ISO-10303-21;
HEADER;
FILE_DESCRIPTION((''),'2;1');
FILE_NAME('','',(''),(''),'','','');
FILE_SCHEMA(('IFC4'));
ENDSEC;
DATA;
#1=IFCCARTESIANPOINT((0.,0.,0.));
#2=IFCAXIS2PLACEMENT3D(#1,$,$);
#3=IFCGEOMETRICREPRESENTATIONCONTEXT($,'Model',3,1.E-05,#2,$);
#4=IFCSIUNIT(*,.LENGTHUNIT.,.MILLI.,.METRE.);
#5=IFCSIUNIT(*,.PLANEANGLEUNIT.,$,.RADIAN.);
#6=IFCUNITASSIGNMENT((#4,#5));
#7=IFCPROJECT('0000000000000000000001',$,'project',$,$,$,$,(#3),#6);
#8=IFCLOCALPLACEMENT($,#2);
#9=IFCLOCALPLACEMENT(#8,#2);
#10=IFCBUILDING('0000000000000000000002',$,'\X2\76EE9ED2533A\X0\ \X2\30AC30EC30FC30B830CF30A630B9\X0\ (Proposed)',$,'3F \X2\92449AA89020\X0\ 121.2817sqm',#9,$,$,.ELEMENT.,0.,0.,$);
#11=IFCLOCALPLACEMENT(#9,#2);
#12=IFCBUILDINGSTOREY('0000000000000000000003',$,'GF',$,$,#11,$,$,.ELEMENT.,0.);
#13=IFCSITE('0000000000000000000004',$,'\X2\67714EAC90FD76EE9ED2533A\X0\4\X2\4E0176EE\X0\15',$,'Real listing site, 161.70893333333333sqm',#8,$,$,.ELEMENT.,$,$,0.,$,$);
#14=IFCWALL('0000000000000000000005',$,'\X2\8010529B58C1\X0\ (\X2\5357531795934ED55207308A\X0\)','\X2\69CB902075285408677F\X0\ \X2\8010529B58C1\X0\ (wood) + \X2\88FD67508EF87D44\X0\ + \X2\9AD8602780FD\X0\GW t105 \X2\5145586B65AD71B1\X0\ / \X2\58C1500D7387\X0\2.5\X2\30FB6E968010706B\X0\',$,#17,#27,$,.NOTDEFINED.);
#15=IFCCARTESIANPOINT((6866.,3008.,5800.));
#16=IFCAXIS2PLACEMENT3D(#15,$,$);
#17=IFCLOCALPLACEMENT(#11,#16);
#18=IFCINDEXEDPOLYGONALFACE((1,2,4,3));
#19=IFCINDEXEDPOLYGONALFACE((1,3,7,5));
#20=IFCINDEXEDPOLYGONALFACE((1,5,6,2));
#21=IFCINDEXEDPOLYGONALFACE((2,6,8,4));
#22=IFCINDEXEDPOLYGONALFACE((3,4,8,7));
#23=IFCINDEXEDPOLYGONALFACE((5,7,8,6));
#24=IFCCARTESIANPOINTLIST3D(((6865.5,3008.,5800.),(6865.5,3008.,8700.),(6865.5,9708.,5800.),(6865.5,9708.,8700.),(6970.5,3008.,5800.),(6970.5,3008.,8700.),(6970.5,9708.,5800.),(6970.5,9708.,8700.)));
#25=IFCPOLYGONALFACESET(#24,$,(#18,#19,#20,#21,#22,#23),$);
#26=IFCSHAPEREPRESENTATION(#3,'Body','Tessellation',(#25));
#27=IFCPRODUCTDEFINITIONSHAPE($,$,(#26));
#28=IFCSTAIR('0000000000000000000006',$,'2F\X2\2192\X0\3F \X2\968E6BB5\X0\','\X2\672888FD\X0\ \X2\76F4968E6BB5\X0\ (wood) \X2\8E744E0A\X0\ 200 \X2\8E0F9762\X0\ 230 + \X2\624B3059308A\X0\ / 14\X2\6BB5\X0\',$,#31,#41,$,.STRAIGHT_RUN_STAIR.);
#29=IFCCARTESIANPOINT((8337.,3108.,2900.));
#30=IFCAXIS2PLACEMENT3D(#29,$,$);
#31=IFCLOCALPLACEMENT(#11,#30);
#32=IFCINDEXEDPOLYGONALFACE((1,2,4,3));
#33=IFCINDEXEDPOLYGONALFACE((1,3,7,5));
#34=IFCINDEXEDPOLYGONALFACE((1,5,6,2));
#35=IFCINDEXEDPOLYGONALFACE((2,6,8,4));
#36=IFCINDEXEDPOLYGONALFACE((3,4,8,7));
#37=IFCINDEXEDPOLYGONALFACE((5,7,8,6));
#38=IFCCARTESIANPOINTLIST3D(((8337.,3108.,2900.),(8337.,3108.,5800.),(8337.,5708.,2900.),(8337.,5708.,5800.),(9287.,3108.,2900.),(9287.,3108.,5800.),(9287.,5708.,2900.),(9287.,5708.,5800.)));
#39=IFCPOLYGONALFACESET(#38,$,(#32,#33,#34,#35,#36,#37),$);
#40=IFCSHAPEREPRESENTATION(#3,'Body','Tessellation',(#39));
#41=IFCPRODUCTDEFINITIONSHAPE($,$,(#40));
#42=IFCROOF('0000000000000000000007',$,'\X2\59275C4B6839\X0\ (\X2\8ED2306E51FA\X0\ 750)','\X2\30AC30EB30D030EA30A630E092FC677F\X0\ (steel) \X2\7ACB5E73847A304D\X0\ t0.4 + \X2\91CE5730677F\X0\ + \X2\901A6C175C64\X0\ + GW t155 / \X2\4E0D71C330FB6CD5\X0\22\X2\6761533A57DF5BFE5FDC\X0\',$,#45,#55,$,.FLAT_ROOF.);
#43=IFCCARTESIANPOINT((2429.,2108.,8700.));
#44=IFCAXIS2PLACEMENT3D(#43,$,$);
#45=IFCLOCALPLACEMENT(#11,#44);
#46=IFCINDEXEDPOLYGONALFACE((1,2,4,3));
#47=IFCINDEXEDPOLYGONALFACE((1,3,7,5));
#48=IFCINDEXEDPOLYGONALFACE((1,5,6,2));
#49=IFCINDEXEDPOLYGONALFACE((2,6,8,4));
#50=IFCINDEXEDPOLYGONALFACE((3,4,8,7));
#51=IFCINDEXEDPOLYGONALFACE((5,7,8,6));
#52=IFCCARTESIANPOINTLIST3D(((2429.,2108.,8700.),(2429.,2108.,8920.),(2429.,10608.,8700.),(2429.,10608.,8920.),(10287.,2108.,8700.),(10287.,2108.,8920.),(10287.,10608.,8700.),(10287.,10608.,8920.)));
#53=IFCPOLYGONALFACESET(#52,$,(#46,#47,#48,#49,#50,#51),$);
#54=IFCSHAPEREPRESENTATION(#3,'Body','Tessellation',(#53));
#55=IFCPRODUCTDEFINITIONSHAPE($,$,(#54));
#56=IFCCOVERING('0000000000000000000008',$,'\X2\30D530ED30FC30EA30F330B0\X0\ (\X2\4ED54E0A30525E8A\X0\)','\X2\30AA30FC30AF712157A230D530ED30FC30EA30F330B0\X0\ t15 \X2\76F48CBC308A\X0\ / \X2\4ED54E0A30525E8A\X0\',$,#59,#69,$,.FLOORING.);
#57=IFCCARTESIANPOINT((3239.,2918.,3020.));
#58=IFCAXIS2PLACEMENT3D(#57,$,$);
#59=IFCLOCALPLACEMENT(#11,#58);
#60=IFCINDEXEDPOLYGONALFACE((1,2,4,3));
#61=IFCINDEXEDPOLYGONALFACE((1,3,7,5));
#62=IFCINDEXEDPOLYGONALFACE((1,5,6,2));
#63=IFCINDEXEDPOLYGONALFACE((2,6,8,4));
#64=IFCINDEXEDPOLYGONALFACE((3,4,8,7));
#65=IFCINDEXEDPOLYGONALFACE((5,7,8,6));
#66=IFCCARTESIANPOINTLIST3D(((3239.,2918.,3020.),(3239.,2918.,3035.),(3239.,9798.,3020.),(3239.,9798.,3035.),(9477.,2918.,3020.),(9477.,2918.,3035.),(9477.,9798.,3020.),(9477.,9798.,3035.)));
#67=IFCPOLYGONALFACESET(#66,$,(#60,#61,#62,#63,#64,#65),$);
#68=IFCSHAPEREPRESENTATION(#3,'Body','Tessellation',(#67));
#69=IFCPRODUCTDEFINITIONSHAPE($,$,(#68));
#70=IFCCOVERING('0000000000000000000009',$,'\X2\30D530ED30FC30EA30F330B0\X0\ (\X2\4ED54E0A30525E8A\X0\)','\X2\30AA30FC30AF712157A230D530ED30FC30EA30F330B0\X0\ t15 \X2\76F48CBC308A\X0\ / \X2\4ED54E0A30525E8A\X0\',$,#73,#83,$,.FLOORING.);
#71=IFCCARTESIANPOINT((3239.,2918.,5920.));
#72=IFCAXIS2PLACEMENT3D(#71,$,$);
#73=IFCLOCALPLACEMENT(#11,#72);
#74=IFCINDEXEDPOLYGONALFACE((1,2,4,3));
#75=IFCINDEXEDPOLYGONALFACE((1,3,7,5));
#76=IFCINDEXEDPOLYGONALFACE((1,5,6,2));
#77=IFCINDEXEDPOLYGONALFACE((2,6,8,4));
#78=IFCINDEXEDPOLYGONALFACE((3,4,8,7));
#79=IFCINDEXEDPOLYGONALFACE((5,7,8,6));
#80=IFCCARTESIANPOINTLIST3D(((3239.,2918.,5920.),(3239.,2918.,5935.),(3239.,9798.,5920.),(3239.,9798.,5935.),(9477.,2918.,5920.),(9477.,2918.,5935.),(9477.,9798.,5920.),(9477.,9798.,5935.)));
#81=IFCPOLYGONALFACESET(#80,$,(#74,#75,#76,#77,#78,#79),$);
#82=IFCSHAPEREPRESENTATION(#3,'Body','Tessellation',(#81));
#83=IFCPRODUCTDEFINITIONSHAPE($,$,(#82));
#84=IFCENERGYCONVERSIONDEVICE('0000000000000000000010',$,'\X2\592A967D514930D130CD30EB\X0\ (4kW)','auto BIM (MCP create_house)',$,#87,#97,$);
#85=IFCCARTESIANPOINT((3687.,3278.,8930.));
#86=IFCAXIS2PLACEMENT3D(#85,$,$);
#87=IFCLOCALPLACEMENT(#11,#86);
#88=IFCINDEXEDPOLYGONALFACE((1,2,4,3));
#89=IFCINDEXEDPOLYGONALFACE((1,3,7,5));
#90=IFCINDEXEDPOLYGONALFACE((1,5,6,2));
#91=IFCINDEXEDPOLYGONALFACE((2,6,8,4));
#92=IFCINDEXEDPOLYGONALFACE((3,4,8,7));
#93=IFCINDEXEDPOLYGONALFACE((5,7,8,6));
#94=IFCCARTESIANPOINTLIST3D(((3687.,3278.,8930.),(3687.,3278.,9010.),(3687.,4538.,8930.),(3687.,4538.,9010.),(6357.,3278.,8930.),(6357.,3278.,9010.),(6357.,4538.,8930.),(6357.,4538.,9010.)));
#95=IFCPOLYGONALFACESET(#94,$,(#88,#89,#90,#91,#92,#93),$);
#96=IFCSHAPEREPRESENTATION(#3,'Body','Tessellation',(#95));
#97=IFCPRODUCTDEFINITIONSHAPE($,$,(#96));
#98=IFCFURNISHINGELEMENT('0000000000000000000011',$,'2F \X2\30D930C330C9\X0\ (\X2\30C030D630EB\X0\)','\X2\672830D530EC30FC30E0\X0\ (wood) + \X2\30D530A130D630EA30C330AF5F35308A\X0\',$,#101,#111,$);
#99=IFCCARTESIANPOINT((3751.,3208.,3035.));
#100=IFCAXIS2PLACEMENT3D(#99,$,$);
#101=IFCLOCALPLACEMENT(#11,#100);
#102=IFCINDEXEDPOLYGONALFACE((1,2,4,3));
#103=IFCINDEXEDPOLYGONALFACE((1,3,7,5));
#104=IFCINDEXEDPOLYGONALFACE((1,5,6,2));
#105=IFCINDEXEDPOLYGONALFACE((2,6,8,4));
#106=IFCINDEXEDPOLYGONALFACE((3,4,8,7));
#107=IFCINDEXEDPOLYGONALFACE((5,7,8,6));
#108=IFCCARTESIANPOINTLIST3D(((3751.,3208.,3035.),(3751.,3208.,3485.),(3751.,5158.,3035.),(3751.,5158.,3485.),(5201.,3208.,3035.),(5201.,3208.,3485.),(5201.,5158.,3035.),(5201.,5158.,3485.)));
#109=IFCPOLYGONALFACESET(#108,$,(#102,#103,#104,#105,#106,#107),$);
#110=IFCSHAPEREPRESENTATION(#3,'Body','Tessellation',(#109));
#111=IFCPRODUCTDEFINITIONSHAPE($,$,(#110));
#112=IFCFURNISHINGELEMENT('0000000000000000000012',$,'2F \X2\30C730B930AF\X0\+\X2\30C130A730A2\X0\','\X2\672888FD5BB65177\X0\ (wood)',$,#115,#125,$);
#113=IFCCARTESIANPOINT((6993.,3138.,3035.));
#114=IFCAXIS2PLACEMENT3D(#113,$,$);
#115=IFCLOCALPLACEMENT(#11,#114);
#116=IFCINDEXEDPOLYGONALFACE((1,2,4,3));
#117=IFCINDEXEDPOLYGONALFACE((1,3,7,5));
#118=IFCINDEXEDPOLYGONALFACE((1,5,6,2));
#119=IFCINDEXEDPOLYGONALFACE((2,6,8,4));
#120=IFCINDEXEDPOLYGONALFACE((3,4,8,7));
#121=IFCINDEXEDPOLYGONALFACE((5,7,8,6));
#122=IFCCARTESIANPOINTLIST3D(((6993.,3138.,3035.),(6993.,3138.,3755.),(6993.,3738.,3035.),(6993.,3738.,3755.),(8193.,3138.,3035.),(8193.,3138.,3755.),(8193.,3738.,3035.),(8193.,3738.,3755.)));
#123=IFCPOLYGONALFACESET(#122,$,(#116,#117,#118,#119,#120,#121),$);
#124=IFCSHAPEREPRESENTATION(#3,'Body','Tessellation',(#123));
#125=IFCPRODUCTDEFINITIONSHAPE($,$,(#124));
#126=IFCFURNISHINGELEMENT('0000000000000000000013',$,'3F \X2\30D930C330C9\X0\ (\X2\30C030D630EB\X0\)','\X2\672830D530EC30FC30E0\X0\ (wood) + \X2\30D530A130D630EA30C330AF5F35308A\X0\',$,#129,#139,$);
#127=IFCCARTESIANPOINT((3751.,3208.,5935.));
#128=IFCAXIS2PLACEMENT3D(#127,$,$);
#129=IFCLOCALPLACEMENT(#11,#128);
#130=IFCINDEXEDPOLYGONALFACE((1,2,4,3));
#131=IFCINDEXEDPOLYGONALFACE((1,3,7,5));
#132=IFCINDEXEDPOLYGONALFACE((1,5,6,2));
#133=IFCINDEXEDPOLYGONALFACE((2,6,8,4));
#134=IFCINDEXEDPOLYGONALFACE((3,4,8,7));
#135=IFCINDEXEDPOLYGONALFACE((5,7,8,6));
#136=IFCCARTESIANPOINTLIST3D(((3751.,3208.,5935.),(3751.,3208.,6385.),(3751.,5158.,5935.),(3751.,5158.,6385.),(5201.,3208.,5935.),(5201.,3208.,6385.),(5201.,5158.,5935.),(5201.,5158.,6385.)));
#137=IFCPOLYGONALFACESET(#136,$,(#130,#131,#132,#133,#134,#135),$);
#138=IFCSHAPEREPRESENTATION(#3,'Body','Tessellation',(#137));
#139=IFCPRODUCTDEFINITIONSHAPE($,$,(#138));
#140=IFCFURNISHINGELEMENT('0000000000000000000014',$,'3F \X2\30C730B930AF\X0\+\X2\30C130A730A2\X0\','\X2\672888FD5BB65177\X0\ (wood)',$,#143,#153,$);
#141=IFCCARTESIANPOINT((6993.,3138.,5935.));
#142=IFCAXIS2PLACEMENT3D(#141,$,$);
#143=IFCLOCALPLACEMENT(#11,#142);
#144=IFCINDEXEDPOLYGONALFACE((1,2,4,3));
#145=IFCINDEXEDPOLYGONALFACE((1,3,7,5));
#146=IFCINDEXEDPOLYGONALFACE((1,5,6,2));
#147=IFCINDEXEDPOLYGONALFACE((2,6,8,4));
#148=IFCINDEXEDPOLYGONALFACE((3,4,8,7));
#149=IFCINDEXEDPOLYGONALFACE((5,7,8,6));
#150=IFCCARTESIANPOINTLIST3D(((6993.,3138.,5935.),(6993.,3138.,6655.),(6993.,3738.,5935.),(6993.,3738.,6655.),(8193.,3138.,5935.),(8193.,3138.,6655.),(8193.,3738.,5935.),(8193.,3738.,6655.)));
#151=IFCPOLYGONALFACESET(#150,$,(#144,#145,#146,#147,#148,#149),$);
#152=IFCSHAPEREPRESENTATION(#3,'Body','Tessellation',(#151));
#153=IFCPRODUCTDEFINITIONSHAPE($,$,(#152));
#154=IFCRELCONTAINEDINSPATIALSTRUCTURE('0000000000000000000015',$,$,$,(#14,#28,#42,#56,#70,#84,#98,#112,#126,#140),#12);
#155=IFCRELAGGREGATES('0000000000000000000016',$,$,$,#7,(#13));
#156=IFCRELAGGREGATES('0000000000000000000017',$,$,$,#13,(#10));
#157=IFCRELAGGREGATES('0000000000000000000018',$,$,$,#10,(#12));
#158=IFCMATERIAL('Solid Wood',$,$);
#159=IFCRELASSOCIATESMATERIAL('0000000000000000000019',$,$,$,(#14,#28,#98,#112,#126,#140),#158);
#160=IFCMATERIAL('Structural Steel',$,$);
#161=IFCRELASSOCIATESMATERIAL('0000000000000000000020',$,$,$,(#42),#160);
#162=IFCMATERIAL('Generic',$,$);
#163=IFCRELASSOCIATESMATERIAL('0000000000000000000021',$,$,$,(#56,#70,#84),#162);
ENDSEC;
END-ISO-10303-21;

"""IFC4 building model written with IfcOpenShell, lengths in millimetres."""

from ifc_helpers import new_model, si_unit, frame, frame_2d, origin, place, context, project, spatial, rectangle, extrude, material, element, save


model = new_model("IFC4")

# Units and contexts
model_context = context("Model", 3, precision=1e-05, world=origin())
ifc_project = project(units=[si_unit("LENGTHUNIT", "METRE", prefix="MILLI"), si_unit("PLANEANGLEUNIT", "RADIAN")], contexts=[model_context])

# Site, building, storey
site_placement = place(None, origin())
site = spatial("IfcSite", under=ifc_project, at=site_placement, Name="東京都目黒区4丁目15", ObjectType="Real listing site, 161.70893333333333sqm", CompositionType="ELEMENT", RefElevation=0.0)
building_placement = place(site_placement, origin())
building = spatial("IfcBuilding", under=site, at=building_placement, Name="目黒区 ガレージハウス (Proposed)", ObjectType="3F 鉄骨造 121.2817sqm", CompositionType="ELEMENT", ElevationOfRefHeight=0.0, ElevationOfTerrain=0.0)
storey_placement = place(building_placement, origin())
storey = spatial("IfcBuildingStorey", under=building, at=storey_placement, Name="GF", CompositionType="ELEMENT", Elevation=0.0)

# Shared definitions
ifc_material_1 = material(Name="Solid Wood")

# Wall
wall_1_placement = place(storey_placement, frame((6866.0, 3008.0, 5800.0)))
element("IfcWall", 1, at=wall_1_placement, inside=storey, material=ifc_material_1, Name="耐力壁 (南北間仕切り)", Description="構造用合板 耐力壁 (wood) + 製材軸組 + 高性能GW t105 充填断熱 / 壁倍率2.5・準耐火", PredefinedType="NOTDEFINED", context=model_context, shape_type="SweptSolid", body=[
    extrude(rectangle(XDim=105.0, YDim=6700.0, at=frame_2d((52.0, 3350.0))), frame((6866.0, 3008.0, 5800.0)), (0.0, 0.0, 1.0), 2900.0),
])

# Stair
stair_placement = place(storey_placement, frame((8337.0, 3108.0, 2900.0)))
element("IfcStair", 2, at=stair_placement, inside=storey, material=ifc_material_1, Name="2F→3F 階段", Description="木製 直階段 (wood) 蹴上 200 踏面 230 + 手すり / 14段", PredefinedType="STRAIGHT_RUN_STAIR", context=model_context, shape_type="SweptSolid", body=[
    extrude(rectangle(XDim=950.0, YDim=2600.0, at=frame_2d((475.0, 1300.0))), frame((8337.0, 3108.0, 2900.0)), (0.0, 0.0, 1.0), 2900.0),
])

# Roof
ifc_material_2 = material(Name="Structural Steel")
roof_placement = place(storey_placement, frame((2429.0, 2108.0, 8700.0)))
element("IfcRoof", 3, at=roof_placement, inside=storey, material=ifc_material_2, Name="大屋根 (軒の出 750)", Description="ガルバリウム鋼板 (steel) 立平葺き t0.4 + 野地板 + 通気層 + GW t155 / 不燃・法22条区域対応", PredefinedType="FLAT_ROOF", context=model_context, shape_type="SweptSolid", body=[
    extrude(rectangle(XDim=7858.0, YDim=8500.0, at=frame_2d((3929.0, 4250.0))), frame((2429.0, 2108.0, 8700.0)), (0.0, 0.0, 1.0), 220.0),
])

# Coverings
ifc_material_3 = material(Name="Generic")
covering_1_placement = place(storey_placement, frame((3239.0, 2918.0, 3020.0)))
element("IfcCovering", 4, at=covering_1_placement, inside=storey, material=ifc_material_3, Name="フローリング (仕上げ床)", Description="オーク無垢フローリング t15 直貼り / 仕上げ床", PredefinedType="FLOORING", context=model_context, shape_type="SweptSolid", body=[
    extrude(rectangle(XDim=6238.0, YDim=6880.0, at=frame_2d((3119.0, 3440.0))), frame((3239.0, 2918.0, 3020.0)), (0.0, 0.0, 1.0), 15.0),
])
covering_2_placement = place(storey_placement, frame((3239.0, 2918.0, 5920.0)))
element("IfcCovering", 5, at=covering_2_placement, inside=storey, material=ifc_material_3, Name="フローリング (仕上げ床)", Description="オーク無垢フローリング t15 直貼り / 仕上げ床", PredefinedType="FLOORING", context=model_context, shape_type="SweptSolid", body=[
    extrude(rectangle(XDim=6238.0, YDim=6880.0, at=frame_2d((3119.0, 3440.0))), frame((3239.0, 2918.0, 5920.0)), (0.0, 0.0, 1.0), 15.0),
])

# Energy conversion device
energy_conversion_device_placement = place(storey_placement, frame((3687.0, 3278.0, 8930.0)))
element("IfcEnergyConversionDevice", 6, at=energy_conversion_device_placement, inside=storey, material=ifc_material_3, Name="太陽光パネル (4kW)", Description="auto BIM (MCP create_house)", context=model_context, shape_type="SweptSolid", body=[
    extrude(rectangle(XDim=2670.0, YDim=1260.0, at=frame_2d((1335.0, 630.0))), frame((3687.0, 3278.0, 8930.0)), (0.0, 0.0, 1.0), 80.0),
])

# Furnishing elements
furnishing_1_placement = place(storey_placement, frame((3751.0, 3208.0, 3035.0)))
element("IfcFurnishingElement", 7, at=furnishing_1_placement, inside=storey, material=ifc_material_1, Name="2F ベッド (ダブル)", Description="木フレーム (wood) + ファブリック張り", context=model_context, shape_type="SweptSolid", body=[
    extrude(rectangle(XDim=1450.0, YDim=1950.0, at=frame_2d((725.0, 975.0))), frame((3751.0, 3208.0, 3035.0)), (0.0, 0.0, 1.0), 450.0),
])
furnishing_2_placement = place(storey_placement, frame((6993.0, 3138.0, 3035.0)))
element("IfcFurnishingElement", 8, at=furnishing_2_placement, inside=storey, material=ifc_material_1, Name="2F デスク+チェア", Description="木製家具 (wood)", context=model_context, shape_type="SweptSolid", body=[
    extrude(rectangle(XDim=1200.0, YDim=600.0, at=frame_2d((600.0, 300.0))), frame((6993.0, 3138.0, 3035.0)), (0.0, 0.0, 1.0), 720.0),
])
furnishing_3_placement = place(storey_placement, frame((3751.0, 3208.0, 5935.0)))
element("IfcFurnishingElement", 9, at=furnishing_3_placement, inside=storey, material=ifc_material_1, Name="3F ベッド (ダブル)", Description="木フレーム (wood) + ファブリック張り", context=model_context, shape_type="SweptSolid", body=[
    extrude(rectangle(XDim=1450.0, YDim=1950.0, at=frame_2d((725.0, 975.0))), frame((3751.0, 3208.0, 5935.0)), (0.0, 0.0, 1.0), 450.0),
])
furnishing_4_placement = place(storey_placement, frame((6993.0, 3138.0, 5935.0)))
element("IfcFurnishingElement", 10, at=furnishing_4_placement, inside=storey, material=ifc_material_1, Name="3F デスク+チェア", Description="木製家具 (wood)", context=model_context, shape_type="SweptSolid", body=[
    extrude(rectangle(XDim=1200.0, YDim=600.0, at=frame_2d((600.0, 300.0))), frame((6993.0, 3138.0, 5935.0)), (0.0, 0.0, 1.0), 720.0),
])

save(model, "model.ifc")
